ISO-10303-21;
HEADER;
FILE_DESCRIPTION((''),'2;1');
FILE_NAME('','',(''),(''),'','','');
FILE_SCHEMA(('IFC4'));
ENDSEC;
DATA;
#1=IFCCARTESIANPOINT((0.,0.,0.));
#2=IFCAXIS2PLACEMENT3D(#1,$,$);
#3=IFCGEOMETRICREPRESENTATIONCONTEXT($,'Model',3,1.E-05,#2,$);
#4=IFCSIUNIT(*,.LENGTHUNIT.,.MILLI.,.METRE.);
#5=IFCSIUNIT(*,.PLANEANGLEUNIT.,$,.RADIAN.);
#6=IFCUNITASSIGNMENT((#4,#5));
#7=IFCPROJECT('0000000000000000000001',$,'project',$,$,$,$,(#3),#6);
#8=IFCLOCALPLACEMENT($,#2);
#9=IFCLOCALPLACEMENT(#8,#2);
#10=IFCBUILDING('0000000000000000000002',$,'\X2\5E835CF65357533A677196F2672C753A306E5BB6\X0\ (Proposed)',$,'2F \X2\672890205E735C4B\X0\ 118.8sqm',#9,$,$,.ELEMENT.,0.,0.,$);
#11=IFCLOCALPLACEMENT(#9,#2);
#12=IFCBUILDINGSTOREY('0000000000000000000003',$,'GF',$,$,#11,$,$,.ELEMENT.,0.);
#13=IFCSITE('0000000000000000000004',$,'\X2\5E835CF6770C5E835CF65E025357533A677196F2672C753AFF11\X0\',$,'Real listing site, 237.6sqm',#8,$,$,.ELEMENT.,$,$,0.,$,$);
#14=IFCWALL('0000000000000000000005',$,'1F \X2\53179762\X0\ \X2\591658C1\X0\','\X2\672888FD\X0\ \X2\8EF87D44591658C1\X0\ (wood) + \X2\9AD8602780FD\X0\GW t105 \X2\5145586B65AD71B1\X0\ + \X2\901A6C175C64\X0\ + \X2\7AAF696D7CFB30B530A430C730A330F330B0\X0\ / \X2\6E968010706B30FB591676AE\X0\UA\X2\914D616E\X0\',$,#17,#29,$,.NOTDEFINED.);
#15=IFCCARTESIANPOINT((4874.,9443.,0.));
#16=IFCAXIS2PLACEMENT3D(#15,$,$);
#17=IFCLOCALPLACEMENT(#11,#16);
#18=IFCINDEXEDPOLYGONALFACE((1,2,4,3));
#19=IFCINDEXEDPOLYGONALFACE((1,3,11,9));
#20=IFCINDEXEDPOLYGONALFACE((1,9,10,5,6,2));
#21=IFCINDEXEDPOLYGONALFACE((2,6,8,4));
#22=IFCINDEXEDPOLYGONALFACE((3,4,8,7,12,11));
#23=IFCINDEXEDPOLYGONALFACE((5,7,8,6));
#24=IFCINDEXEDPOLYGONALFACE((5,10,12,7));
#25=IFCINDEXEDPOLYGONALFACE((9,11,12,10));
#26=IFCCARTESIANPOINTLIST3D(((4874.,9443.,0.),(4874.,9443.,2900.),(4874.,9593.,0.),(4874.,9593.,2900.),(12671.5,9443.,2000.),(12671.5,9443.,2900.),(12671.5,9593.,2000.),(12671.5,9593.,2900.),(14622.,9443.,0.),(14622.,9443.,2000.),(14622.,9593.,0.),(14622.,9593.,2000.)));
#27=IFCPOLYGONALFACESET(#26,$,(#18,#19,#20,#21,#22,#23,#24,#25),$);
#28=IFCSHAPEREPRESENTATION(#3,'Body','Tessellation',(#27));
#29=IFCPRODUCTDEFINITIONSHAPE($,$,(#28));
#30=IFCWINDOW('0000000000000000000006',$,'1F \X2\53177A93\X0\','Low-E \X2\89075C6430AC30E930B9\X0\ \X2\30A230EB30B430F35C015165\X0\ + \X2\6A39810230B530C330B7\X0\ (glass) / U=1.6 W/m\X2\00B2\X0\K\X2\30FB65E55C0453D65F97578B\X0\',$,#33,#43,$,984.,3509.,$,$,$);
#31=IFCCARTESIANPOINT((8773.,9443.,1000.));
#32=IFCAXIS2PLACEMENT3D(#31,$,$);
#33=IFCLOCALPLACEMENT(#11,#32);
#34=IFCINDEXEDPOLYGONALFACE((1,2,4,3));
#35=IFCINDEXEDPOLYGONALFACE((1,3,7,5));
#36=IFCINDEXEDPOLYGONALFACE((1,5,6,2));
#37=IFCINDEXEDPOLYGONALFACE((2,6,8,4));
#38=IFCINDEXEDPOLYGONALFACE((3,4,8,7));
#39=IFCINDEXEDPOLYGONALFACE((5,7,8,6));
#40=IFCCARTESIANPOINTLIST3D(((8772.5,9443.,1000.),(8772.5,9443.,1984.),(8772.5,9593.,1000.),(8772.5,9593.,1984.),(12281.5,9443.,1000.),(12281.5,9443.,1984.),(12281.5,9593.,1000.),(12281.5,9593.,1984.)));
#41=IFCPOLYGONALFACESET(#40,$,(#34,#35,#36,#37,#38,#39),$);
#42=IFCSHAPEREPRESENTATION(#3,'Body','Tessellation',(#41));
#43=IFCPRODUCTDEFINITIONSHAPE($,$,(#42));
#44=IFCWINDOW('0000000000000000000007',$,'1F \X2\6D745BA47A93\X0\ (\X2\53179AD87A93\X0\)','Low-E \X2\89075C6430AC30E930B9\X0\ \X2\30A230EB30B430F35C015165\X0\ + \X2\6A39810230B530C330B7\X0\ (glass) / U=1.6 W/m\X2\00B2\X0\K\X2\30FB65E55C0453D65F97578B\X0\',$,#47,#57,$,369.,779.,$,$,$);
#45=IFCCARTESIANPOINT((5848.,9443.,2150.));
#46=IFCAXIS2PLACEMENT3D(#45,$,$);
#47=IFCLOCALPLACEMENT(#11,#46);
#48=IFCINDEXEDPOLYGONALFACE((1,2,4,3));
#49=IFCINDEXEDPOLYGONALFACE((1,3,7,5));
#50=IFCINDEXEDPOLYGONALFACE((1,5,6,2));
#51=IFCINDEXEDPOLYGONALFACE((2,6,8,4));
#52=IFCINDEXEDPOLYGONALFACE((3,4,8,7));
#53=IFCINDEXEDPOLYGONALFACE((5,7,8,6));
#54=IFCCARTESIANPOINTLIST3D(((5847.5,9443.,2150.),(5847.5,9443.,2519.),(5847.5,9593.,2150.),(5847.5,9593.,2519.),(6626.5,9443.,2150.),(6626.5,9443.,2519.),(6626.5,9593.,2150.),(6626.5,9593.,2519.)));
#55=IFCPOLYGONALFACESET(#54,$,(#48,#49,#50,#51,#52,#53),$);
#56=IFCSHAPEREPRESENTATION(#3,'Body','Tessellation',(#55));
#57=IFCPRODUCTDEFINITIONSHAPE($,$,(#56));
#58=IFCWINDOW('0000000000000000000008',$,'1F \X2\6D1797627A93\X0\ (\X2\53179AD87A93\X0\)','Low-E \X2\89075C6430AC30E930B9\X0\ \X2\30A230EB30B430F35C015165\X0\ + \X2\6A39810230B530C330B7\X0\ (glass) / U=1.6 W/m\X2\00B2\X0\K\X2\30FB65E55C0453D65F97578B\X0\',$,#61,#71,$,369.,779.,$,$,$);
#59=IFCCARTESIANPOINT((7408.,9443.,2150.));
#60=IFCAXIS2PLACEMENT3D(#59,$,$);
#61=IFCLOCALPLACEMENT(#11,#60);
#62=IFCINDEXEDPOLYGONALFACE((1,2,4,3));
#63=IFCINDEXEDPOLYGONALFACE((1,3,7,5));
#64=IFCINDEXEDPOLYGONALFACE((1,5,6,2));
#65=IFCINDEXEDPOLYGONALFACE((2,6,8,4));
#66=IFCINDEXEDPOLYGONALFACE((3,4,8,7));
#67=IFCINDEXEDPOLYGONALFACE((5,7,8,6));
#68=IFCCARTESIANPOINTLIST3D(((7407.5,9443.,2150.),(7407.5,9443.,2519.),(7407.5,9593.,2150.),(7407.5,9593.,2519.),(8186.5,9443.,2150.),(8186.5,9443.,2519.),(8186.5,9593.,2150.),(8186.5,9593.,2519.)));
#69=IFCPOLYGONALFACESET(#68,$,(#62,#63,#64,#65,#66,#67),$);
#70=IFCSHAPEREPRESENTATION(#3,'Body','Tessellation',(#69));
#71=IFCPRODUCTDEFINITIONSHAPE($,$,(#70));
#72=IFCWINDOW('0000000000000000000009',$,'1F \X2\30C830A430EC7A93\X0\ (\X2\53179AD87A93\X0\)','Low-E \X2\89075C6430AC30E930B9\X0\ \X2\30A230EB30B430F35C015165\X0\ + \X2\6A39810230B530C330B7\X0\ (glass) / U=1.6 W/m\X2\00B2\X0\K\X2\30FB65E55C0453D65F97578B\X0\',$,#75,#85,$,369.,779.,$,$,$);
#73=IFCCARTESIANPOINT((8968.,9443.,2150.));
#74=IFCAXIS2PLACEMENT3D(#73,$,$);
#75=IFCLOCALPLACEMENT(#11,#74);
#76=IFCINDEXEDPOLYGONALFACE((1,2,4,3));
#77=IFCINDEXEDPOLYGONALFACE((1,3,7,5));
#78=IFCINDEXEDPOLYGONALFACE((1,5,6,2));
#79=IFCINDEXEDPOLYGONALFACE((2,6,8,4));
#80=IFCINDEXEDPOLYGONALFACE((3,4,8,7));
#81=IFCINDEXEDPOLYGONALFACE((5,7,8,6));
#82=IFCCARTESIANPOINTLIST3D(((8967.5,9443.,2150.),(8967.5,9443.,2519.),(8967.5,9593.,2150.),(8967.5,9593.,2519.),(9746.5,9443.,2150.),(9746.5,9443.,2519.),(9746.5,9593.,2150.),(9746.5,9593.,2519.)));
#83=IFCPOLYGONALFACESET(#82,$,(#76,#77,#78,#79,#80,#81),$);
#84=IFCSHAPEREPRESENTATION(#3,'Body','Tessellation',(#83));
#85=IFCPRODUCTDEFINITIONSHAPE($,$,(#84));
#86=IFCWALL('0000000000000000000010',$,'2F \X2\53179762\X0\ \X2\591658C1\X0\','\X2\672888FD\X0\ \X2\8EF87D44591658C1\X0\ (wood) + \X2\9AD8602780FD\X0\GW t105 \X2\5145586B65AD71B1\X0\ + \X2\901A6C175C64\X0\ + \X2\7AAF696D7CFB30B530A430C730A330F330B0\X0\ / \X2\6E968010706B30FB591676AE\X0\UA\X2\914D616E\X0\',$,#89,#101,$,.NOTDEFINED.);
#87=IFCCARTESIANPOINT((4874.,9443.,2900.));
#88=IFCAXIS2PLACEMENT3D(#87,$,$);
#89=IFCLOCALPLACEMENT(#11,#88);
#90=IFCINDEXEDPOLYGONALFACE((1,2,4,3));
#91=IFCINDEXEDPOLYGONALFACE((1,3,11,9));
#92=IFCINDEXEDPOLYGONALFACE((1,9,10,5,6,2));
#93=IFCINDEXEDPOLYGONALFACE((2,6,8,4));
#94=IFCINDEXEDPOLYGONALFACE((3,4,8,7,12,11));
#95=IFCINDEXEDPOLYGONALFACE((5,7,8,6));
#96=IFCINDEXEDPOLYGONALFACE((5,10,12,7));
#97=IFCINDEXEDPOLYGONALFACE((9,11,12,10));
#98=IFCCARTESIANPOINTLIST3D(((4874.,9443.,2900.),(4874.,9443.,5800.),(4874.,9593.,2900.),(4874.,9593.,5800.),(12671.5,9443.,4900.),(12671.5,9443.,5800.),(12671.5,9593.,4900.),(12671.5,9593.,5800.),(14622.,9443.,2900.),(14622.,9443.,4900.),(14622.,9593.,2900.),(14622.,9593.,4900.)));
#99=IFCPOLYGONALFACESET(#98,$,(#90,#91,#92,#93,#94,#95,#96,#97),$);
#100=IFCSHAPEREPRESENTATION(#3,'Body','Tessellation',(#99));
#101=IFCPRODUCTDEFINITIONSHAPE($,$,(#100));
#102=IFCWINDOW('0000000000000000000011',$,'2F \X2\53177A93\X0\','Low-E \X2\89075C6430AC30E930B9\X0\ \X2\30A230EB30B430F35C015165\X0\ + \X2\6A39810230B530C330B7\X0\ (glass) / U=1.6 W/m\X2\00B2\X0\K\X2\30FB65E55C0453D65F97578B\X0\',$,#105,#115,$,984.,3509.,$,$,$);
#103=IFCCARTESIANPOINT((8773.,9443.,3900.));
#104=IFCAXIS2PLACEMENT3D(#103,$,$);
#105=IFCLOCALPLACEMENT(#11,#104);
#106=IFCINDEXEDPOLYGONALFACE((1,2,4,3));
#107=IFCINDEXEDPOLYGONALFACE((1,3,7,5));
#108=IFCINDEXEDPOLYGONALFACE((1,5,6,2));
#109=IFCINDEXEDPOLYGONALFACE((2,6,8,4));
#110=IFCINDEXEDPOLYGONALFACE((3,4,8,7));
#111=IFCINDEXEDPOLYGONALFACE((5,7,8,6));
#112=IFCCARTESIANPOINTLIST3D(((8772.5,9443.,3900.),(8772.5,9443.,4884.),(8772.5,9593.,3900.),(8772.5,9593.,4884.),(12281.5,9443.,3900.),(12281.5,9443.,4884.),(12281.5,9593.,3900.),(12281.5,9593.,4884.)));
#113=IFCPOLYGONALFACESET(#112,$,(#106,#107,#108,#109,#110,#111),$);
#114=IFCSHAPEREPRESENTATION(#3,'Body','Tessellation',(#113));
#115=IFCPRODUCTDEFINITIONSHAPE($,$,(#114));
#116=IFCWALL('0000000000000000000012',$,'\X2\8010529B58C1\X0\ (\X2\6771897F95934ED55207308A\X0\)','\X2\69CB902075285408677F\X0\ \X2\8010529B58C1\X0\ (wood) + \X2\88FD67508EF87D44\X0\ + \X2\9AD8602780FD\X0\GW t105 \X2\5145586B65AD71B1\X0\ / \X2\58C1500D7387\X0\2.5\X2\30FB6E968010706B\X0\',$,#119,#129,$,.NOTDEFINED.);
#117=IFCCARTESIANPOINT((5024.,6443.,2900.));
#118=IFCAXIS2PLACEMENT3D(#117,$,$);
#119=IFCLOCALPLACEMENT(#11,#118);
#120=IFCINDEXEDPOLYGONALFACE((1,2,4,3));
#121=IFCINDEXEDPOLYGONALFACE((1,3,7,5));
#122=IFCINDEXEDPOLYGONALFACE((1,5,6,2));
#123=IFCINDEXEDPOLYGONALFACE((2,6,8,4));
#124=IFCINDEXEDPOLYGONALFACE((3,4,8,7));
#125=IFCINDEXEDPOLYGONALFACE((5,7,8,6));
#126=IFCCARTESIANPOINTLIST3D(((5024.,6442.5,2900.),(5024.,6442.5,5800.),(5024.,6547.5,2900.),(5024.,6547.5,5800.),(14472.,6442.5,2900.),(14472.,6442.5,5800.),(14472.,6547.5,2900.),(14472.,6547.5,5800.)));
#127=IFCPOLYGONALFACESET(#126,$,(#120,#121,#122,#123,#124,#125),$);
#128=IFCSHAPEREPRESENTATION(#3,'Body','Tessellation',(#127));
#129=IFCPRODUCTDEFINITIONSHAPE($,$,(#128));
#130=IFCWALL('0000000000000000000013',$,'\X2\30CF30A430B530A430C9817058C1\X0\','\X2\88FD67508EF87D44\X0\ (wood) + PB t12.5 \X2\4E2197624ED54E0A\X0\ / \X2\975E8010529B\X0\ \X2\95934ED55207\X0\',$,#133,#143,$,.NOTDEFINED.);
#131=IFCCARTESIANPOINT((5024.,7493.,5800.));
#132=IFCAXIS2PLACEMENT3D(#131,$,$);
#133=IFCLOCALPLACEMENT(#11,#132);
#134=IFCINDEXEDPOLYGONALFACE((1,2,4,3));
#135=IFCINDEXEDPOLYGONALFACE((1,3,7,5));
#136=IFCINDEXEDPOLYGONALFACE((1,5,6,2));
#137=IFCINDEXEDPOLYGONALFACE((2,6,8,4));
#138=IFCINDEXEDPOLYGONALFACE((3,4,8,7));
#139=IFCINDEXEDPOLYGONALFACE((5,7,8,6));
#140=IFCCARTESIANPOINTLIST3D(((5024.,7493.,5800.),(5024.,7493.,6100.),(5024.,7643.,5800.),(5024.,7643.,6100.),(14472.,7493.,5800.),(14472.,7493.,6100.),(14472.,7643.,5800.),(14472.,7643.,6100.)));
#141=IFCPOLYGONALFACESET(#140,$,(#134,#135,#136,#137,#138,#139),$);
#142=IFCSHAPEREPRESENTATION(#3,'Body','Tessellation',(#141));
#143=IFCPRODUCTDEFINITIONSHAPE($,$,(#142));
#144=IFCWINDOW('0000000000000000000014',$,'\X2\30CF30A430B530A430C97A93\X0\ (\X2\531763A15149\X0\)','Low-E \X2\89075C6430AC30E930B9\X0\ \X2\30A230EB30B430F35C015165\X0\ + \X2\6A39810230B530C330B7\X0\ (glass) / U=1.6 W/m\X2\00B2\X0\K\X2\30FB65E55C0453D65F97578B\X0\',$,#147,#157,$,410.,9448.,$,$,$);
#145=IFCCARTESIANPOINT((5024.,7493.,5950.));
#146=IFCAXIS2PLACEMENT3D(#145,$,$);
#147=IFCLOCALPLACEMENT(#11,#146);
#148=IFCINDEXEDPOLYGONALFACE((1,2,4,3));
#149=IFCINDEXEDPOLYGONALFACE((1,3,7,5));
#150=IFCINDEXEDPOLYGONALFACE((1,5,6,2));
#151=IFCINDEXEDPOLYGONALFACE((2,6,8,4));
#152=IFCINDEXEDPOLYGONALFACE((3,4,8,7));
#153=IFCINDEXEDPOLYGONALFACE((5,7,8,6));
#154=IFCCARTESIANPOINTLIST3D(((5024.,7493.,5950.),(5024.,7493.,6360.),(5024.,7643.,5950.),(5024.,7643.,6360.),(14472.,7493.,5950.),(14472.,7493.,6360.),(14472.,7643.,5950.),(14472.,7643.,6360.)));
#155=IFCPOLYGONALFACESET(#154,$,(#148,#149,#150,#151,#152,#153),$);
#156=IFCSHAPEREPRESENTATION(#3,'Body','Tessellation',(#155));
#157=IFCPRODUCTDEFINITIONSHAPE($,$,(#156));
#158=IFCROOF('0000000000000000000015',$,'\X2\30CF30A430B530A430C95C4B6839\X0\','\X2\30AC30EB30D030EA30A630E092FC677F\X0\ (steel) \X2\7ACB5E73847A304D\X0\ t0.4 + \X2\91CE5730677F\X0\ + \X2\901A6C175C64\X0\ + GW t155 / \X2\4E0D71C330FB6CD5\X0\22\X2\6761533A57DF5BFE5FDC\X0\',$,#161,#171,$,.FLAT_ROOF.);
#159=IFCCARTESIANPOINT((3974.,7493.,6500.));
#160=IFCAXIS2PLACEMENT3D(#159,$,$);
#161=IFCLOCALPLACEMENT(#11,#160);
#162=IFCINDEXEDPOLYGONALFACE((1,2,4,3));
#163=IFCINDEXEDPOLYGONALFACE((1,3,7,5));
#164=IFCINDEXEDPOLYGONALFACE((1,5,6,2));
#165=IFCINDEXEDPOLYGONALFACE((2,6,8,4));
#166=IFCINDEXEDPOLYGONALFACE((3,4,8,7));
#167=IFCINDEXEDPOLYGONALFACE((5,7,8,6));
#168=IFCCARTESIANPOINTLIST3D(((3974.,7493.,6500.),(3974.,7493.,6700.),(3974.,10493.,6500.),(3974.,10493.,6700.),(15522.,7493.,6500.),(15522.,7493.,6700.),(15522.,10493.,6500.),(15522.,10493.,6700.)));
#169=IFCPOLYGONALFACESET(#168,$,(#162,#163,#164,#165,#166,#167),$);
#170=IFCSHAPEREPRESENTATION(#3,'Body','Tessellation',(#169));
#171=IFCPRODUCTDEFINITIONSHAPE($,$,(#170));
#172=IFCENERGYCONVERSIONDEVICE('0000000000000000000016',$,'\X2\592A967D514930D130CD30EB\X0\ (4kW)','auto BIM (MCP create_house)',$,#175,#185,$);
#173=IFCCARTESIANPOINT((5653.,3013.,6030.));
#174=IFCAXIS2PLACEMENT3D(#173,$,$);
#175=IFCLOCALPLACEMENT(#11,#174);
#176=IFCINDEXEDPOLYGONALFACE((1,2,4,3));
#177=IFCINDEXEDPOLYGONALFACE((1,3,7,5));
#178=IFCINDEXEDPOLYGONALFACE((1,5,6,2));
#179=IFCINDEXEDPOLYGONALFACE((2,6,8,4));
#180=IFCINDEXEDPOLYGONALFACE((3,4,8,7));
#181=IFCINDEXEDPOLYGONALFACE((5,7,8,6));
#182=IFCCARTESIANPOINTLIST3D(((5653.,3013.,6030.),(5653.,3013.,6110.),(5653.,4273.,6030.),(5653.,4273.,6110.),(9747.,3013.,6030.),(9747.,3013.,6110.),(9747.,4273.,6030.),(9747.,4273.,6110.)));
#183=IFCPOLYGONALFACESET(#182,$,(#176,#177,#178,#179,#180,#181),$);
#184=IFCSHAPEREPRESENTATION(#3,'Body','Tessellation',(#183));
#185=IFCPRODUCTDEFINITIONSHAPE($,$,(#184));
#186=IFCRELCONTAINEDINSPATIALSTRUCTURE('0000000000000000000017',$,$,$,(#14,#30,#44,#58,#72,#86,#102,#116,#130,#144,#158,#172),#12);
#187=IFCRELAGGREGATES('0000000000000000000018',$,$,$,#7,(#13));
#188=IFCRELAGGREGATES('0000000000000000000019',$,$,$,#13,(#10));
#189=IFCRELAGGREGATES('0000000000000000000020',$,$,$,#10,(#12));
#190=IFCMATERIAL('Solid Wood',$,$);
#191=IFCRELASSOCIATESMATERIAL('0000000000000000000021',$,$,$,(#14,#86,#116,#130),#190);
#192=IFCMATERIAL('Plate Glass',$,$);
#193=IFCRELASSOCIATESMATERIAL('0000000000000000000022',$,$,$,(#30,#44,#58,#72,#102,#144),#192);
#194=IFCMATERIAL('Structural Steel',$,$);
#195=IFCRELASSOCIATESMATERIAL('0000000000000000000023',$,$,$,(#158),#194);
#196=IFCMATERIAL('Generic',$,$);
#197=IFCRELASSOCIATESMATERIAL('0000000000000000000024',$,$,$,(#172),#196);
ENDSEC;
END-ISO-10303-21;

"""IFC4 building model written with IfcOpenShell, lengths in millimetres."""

from ifc_helpers import new_model, si_unit, frame, frame_2d, origin, place, context, project, spatial, rectangle, extrude, material, element, fill, save


model = new_model("IFC4")

# Units and contexts
model_context = context("Model", 3, precision=1e-05, world=origin())
ifc_project = project(units=[si_unit("LENGTHUNIT", "METRE", prefix="MILLI"), si_unit("PLANEANGLEUNIT", "RADIAN")], contexts=[model_context])

# Site, building, storey
site_placement = place(None, origin())
site = spatial("IfcSite", under=ifc_project, at=site_placement, Name="広島県広島市南区東雲本町１", ObjectType="Real listing site, 237.6sqm", CompositionType="ELEMENT", RefElevation=0.0)
building_placement = place(site_placement, origin())
building = spatial("IfcBuilding", under=site, at=building_placement, Name="広島南区東雲本町の家 (Proposed)", ObjectType="2F 木造平屋 118.8sqm", CompositionType="ELEMENT", ElevationOfRefHeight=0.0, ElevationOfTerrain=0.0)
storey_placement = place(building_placement, origin())
storey = spatial("IfcBuildingStorey", under=building, at=storey_placement, Name="GF", CompositionType="ELEMENT", Elevation=0.0)

# Wall, openings, windows
ifc_material_1 = material(Name="Solid Wood")
wall_1_placement = place(storey_placement, frame((4874.0, 9443.0, 0.0)))
wall_1 = element("IfcWall", 1, at=wall_1_placement, inside=storey, material=ifc_material_1, Name="1F 北面 外壁", Description="木製 軸組外壁 (wood) + 高性能GW t105 充填断熱 + 通気層 + 窯業系サイディング / 準耐火・外皮UA配慮", PredefinedType="NOTDEFINED", context=model_context, shape_type="SweptSolid", body=[
    extrude(rectangle(XDim=9748.0, YDim=150.0, at=frame_2d((4874.0, 75.0))), frame((4874.0, 9443.0, 0.0)), (0.0, 0.0, 1.0), 2900.0),
])
opening_1_placement = place(storey_placement, frame((8773.0, 9443.0, 1000.0)))
opening_1 = element("IfcOpeningElement", 2, at=opening_1_placement, cuts=wall_1, PredefinedType="NOTDEFINED", context=model_context, shape_type="SweptSolid", body=[
    extrude(rectangle(XDim=3509.0, YDim=150.0, at=frame_2d((1754.0, 75.0))), frame((8773.0, 9443.0, 1000.0)), (0.0, 0.0, 1.0), 984.0),
])
opening_2_placement = place(storey_placement, frame((5848.0, 9443.0, 2150.0)))
opening_2 = element("IfcOpeningElement", 3, at=opening_2_placement, cuts=wall_1, PredefinedType="NOTDEFINED", context=model_context, shape_type="SweptSolid", body=[
    extrude(rectangle(XDim=779.0, YDim=150.0, at=frame_2d((389.0, 75.0))), frame((5848.0, 9443.0, 2150.0)), (0.0, 0.0, 1.0), 369.0),
])
opening_3_placement = place(storey_placement, frame((7408.0, 9443.0, 2150.0)))
opening_3 = element("IfcOpeningElement", 4, at=opening_3_placement, cuts=wall_1, PredefinedType="NOTDEFINED", context=model_context, shape_type="SweptSolid", body=[
    extrude(rectangle(XDim=779.0, YDim=150.0, at=frame_2d((389.0, 75.0))), frame((7408.0, 9443.0, 2150.0)), (0.0, 0.0, 1.0), 369.0),
])
opening_4_placement = place(storey_placement, frame((8968.0, 9443.0, 2150.0)))
opening_4 = element("IfcOpeningElement", 5, at=opening_4_placement, cuts=wall_1, PredefinedType="NOTDEFINED", context=model_context, shape_type="SweptSolid", body=[
    extrude(rectangle(XDim=779.0, YDim=150.0, at=frame_2d((389.0, 75.0))), frame((8968.0, 9443.0, 2150.0)), (0.0, 0.0, 1.0), 369.0),
])
ifc_material_2 = material(Name="Plate Glass")
window_1_placement = place(storey_placement, frame((8773.0, 9443.0, 1000.0)))
window_1 = element("IfcWindow", 6, at=window_1_placement, inside=storey, material=ifc_material_2, Name="1F 北窓", Description="Low-E 複層ガラス アルゴン封入 + 樹脂サッシ (glass) / U=1.6 W/m²K・日射取得型", OverallHeight=984.0, OverallWidth=3509.0, context=model_context, shape_type="SweptSolid", body=[
    extrude(rectangle(XDim=3509.0, YDim=150.0, at=frame_2d((1754.0, 75.0))), frame((8773.0, 9443.0, 1000.0)), (0.0, 0.0, 1.0), 984.0),
])
fill(opening_1, window_1)
window_2_placement = place(storey_placement, frame((5848.0, 9443.0, 2150.0)))
window_2 = element("IfcWindow", 7, at=window_2_placement, inside=storey, material=ifc_material_2, Name="1F 浴室窓 (北高窓)", Description="Low-E 複層ガラス アルゴン封入 + 樹脂サッシ (glass) / U=1.6 W/m²K・日射取得型", OverallHeight=369.0, OverallWidth=779.0, context=model_context, shape_type="SweptSolid", body=[
    extrude(rectangle(XDim=779.0, YDim=150.0, at=frame_2d((389.0, 75.0))), frame((5848.0, 9443.0, 2150.0)), (0.0, 0.0, 1.0), 369.0),
])
fill(opening_2, window_2)
window_3_placement = place(storey_placement, frame((7408.0, 9443.0, 2150.0)))
window_3 = element("IfcWindow", 8, at=window_3_placement, inside=storey, material=ifc_material_2, Name="1F 洗面窓 (北高窓)", Description="Low-E 複層ガラス アルゴン封入 + 樹脂サッシ (glass) / U=1.6 W/m²K・日射取得型", OverallHeight=369.0, OverallWidth=779.0, context=model_context, shape_type="SweptSolid", body=[
    extrude(rectangle(XDim=779.0, YDim=150.0, at=frame_2d((389.0, 75.0))), frame((7408.0, 9443.0, 2150.0)), (0.0, 0.0, 1.0), 369.0),
])
fill(opening_3, window_3)
window_4_placement = place(storey_placement, frame((8968.0, 9443.0, 2150.0)))
window_4 = element("IfcWindow", 9, at=window_4_placement, inside=storey, material=ifc_material_2, Name="1F トイレ窓 (北高窓)", Description="Low-E 複層ガラス アルゴン封入 + 樹脂サッシ (glass) / U=1.6 W/m²K・日射取得型", OverallHeight=369.0, OverallWidth=779.0, context=model_context, shape_type="SweptSolid", body=[
    extrude(rectangle(XDim=779.0, YDim=150.0, at=frame_2d((389.0, 75.0))), frame((8968.0, 9443.0, 2150.0)), (0.0, 0.0, 1.0), 369.0),
])
fill(opening_4, window_4)

# Wall, opening, window
wall_2_placement = place(storey_placement, frame((4874.0, 9443.0, 2900.0)))
wall_2 = element("IfcWall", 10, at=wall_2_placement, inside=storey, material=ifc_material_1, Name="2F 北面 外壁", Description="木製 軸組外壁 (wood) + 高性能GW t105 充填断熱 + 通気層 + 窯業系サイディング / 準耐火・外皮UA配慮", PredefinedType="NOTDEFINED", context=model_context, shape_type="SweptSolid", body=[
    extrude(rectangle(XDim=9748.0, YDim=150.0, at=frame_2d((4874.0, 75.0))), frame((4874.0, 9443.0, 2900.0)), (0.0, 0.0, 1.0), 2900.0),
])
opening_5_placement = place(storey_placement, frame((8773.0, 9443.0, 3900.0)))
opening_5 = element("IfcOpeningElement", 11, at=opening_5_placement, cuts=wall_2, PredefinedType="NOTDEFINED", context=model_context, shape_type="SweptSolid", body=[
    extrude(rectangle(XDim=3509.0, YDim=150.0, at=frame_2d((1754.0, 75.0))), frame((8773.0, 9443.0, 3900.0)), (0.0, 0.0, 1.0), 984.0),
])
window_5_placement = place(storey_placement, frame((8773.0, 9443.0, 3900.0)))
window_5 = element("IfcWindow", 12, at=window_5_placement, inside=storey, material=ifc_material_2, Name="2F 北窓", Description="Low-E 複層ガラス アルゴン封入 + 樹脂サッシ (glass) / U=1.6 W/m²K・日射取得型", OverallHeight=984.0, OverallWidth=3509.0, context=model_context, shape_type="SweptSolid", body=[
    extrude(rectangle(XDim=3509.0, YDim=150.0, at=frame_2d((1754.0, 75.0))), frame((8773.0, 9443.0, 3900.0)), (0.0, 0.0, 1.0), 984.0),
])
fill(opening_5, window_5)

# Wall
wall_3_placement = place(storey_placement, frame((5024.0, 6443.0, 2900.0)))
element("IfcWall", 13, at=wall_3_placement, inside=storey, material=ifc_material_1, Name="耐力壁 (東西間仕切り)", Description="構造用合板 耐力壁 (wood) + 製材軸組 + 高性能GW t105 充填断熱 / 壁倍率2.5・準耐火", PredefinedType="NOTDEFINED", context=model_context, shape_type="SweptSolid", body=[
    extrude(rectangle(XDim=9448.0, YDim=105.0, at=frame_2d((4724.0, 52.0))), frame((5024.0, 6443.0, 2900.0)), (0.0, 0.0, 1.0), 2900.0),
])

# Wall, opening, window
wall_4_placement = place(storey_placement, frame((5024.0, 7493.0, 5800.0)))
wall_4 = element("IfcWall", 14, at=wall_4_placement, inside=storey, material=ifc_material_1, Name="ハイサイド腰壁", Description="製材軸組 (wood) + PB t12.5 両面仕上 / 非耐力 間仕切", PredefinedType="NOTDEFINED", context=model_context, shape_type="SweptSolid", body=[
    extrude(rectangle(XDim=9448.0, YDim=150.0, at=frame_2d((4724.0, 75.0))), frame((5024.0, 7493.0, 5800.0)), (0.0, 0.0, 1.0), 700.0),
])
opening_6_placement = place(storey_placement, frame((5024.0, 7493.0, 5950.0)))
opening_6 = element("IfcOpeningElement", 15, at=opening_6_placement, cuts=wall_4, PredefinedType="NOTDEFINED", context=model_context, shape_type="SweptSolid", body=[
    extrude(rectangle(XDim=9448.0, YDim=150.0, at=frame_2d((4724.0, 75.0))), frame((5024.0, 7493.0, 5950.0)), (0.0, 0.0, 1.0), 410.0),
])
window_6_placement = place(storey_placement, frame((5024.0, 7493.0, 5950.0)))
window_6 = element("IfcWindow", 16, at=window_6_placement, inside=storey, material=ifc_material_2, Name="ハイサイド窓 (北採光)", Description="Low-E 複層ガラス アルゴン封入 + 樹脂サッシ (glass) / U=1.6 W/m²K・日射取得型", OverallHeight=410.0, OverallWidth=9448.0, context=model_context, shape_type="SweptSolid", body=[
    extrude(rectangle(XDim=9448.0, YDim=150.0, at=frame_2d((4724.0, 75.0))), frame((5024.0, 7493.0, 5950.0)), (0.0, 0.0, 1.0), 410.0),
])
fill(opening_6, window_6)

# Roof
ifc_material_3 = material(Name="Structural Steel")
roof_placement = place(storey_placement, frame((3974.0, 7493.0, 6500.0)))
element("IfcRoof", 17, at=roof_placement, inside=storey, material=ifc_material_3, Name="ハイサイド屋根", Description="ガルバリウム鋼板 (steel) 立平葺き t0.4 + 野地板 + 通気層 + GW t155 / 不燃・法22条区域対応", PredefinedType="FLAT_ROOF", context=model_context, shape_type="SweptSolid", body=[
    extrude(rectangle(XDim=11548.0, YDim=3000.0, at=frame_2d((5774.0, 1500.0))), frame((3974.0, 7493.0, 6500.0)), (0.0, 0.0, 1.0), 200.0),
])

# Energy conversion device
ifc_material_4 = material(Name="Generic")
energy_conversion_device_placement = place(storey_placement, frame((5653.0, 3013.0, 6030.0)))
element("IfcEnergyConversionDevice", 18, at=energy_conversion_device_placement, inside=storey, material=ifc_material_4, Name="太陽光パネル (4kW)", Description="auto BIM (MCP create_house)", context=model_context, shape_type="SweptSolid", body=[
    extrude(rectangle(XDim=4094.0, YDim=1260.0, at=frame_2d((2047.0, 630.0))), frame((5653.0, 3013.0, 6030.0)), (0.0, 0.0, 1.0), 80.0),
])

save(model, "model.ifc")
